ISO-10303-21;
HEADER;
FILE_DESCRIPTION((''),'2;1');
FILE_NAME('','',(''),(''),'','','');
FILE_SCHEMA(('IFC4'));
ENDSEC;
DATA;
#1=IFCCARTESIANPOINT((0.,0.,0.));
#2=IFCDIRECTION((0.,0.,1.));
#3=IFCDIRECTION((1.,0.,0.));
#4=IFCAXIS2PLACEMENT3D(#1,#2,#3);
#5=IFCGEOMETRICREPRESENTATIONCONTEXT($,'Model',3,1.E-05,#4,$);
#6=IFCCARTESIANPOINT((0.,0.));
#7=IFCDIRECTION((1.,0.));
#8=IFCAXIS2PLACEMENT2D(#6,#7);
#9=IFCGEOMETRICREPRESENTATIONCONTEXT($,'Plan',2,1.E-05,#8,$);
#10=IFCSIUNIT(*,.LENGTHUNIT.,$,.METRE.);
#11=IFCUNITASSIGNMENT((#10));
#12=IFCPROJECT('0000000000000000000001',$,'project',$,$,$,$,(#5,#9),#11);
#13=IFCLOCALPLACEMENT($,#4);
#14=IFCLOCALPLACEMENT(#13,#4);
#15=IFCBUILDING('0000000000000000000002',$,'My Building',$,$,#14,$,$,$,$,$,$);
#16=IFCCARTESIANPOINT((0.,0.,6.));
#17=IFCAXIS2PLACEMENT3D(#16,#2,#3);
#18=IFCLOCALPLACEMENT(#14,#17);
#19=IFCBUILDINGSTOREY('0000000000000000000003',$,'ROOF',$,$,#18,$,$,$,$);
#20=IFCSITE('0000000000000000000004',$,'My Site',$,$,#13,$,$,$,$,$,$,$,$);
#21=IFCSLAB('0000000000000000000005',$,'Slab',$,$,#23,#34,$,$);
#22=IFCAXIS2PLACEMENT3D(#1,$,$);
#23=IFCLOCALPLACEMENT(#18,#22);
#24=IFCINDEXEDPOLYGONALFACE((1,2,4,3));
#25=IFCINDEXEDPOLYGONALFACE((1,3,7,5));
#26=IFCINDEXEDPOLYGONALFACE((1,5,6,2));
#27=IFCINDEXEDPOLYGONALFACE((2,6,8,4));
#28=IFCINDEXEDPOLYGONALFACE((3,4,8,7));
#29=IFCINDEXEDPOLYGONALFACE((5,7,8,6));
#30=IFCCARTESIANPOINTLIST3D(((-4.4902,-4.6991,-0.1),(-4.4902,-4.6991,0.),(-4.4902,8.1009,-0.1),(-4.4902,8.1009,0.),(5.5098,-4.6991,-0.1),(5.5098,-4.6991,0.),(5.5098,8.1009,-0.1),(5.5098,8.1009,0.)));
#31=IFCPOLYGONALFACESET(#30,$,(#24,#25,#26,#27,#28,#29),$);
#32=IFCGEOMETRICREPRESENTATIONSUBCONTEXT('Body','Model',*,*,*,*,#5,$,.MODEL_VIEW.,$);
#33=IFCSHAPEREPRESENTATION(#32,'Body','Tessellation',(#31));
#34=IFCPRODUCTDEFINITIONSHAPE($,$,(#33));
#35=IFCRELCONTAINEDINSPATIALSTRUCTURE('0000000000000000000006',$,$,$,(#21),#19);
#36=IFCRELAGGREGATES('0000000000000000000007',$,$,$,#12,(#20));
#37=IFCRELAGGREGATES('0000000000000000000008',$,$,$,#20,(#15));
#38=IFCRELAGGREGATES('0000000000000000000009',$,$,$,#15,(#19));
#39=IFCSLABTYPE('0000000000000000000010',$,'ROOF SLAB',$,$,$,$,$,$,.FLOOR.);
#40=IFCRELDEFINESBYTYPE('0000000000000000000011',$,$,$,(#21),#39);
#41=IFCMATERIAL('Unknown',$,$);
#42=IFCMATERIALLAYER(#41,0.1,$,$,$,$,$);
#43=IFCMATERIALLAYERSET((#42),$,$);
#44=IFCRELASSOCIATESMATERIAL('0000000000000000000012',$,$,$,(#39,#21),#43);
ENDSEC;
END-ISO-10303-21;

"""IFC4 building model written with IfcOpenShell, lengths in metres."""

from ifc_helpers import new_model, si_unit, frame, origin_with_axes, origin_2d_with_axis, place, context, subcontext, project, spatial, indexed_curve, outline, extrude, material, layer, layer_set, layer_usage, type_object, element, save


model = new_model("IFC4")

# Units and contexts
model_context = context("Model", 3, precision=1e-05, world=origin_with_axes())
plan_context = context("Plan", 2, precision=1e-05, world=origin_2d_with_axis())
body_context = subcontext(model_context, "Body", "Model", "MODEL_VIEW")
ifc_project = project(units=[si_unit("LENGTHUNIT", "METRE")], contexts=[model_context, plan_context])

# Site, building, storey
site_placement = place(None, origin_with_axes())
site = spatial("IfcSite", under=ifc_project, at=site_placement, Name="My Site")
building_placement = place(site_placement, origin_with_axes())
building = spatial("IfcBuilding", under=site, at=building_placement, Name="My Building")
storey_placement = place(building_placement, frame((0.0, 0.0, 6.0), z_axis=(0.0, 0.0, 1.0), x_axis=(1.0, 0.0, 0.0)))
storey = spatial("IfcBuildingStorey", under=building, at=storey_placement, Name="ROOF")

# Slab
ifc_material = material(Name="Unknown")
ifc_layer = layer(ifc_material, 0.1)
ifc_layer_set = layer_set([ifc_layer])
ifc_layer_usage = layer_usage(ifc_layer_set, "AXIS3", "POSITIVE", -0.1)
slab_type = type_object("IfcSlabType", Name="ROOF SLAB", PredefinedType="FLOOR", material=ifc_layer_set)
slab_placement = place(storey_placement, frame((-4.4902, 8.1009, 0.0), z_axis=(0.0, 0.0, 1.0), x_axis=(1.0, 0.0, 0.0)))
element("IfcSlab", 1, at=slab_placement, inside=storey, type_object=slab_type, material=ifc_layer_usage, Name="Slab", context=body_context, shape_type="SweptSolid", body=[
    extrude(outline(indexed_curve([(0.0, 0.0), (0.0, -12.8), (10.0, -12.8), (10.0, 0.0), (0.0, 0.0)])), frame((0.0, 0.0, -0.1), z_axis=(0.0, 0.0, 1.0), x_axis=(1.0, 0.0, 0.0)), (0.0, 0.0, 1.0), 0.1),
])

save(model, "model.ifc")
